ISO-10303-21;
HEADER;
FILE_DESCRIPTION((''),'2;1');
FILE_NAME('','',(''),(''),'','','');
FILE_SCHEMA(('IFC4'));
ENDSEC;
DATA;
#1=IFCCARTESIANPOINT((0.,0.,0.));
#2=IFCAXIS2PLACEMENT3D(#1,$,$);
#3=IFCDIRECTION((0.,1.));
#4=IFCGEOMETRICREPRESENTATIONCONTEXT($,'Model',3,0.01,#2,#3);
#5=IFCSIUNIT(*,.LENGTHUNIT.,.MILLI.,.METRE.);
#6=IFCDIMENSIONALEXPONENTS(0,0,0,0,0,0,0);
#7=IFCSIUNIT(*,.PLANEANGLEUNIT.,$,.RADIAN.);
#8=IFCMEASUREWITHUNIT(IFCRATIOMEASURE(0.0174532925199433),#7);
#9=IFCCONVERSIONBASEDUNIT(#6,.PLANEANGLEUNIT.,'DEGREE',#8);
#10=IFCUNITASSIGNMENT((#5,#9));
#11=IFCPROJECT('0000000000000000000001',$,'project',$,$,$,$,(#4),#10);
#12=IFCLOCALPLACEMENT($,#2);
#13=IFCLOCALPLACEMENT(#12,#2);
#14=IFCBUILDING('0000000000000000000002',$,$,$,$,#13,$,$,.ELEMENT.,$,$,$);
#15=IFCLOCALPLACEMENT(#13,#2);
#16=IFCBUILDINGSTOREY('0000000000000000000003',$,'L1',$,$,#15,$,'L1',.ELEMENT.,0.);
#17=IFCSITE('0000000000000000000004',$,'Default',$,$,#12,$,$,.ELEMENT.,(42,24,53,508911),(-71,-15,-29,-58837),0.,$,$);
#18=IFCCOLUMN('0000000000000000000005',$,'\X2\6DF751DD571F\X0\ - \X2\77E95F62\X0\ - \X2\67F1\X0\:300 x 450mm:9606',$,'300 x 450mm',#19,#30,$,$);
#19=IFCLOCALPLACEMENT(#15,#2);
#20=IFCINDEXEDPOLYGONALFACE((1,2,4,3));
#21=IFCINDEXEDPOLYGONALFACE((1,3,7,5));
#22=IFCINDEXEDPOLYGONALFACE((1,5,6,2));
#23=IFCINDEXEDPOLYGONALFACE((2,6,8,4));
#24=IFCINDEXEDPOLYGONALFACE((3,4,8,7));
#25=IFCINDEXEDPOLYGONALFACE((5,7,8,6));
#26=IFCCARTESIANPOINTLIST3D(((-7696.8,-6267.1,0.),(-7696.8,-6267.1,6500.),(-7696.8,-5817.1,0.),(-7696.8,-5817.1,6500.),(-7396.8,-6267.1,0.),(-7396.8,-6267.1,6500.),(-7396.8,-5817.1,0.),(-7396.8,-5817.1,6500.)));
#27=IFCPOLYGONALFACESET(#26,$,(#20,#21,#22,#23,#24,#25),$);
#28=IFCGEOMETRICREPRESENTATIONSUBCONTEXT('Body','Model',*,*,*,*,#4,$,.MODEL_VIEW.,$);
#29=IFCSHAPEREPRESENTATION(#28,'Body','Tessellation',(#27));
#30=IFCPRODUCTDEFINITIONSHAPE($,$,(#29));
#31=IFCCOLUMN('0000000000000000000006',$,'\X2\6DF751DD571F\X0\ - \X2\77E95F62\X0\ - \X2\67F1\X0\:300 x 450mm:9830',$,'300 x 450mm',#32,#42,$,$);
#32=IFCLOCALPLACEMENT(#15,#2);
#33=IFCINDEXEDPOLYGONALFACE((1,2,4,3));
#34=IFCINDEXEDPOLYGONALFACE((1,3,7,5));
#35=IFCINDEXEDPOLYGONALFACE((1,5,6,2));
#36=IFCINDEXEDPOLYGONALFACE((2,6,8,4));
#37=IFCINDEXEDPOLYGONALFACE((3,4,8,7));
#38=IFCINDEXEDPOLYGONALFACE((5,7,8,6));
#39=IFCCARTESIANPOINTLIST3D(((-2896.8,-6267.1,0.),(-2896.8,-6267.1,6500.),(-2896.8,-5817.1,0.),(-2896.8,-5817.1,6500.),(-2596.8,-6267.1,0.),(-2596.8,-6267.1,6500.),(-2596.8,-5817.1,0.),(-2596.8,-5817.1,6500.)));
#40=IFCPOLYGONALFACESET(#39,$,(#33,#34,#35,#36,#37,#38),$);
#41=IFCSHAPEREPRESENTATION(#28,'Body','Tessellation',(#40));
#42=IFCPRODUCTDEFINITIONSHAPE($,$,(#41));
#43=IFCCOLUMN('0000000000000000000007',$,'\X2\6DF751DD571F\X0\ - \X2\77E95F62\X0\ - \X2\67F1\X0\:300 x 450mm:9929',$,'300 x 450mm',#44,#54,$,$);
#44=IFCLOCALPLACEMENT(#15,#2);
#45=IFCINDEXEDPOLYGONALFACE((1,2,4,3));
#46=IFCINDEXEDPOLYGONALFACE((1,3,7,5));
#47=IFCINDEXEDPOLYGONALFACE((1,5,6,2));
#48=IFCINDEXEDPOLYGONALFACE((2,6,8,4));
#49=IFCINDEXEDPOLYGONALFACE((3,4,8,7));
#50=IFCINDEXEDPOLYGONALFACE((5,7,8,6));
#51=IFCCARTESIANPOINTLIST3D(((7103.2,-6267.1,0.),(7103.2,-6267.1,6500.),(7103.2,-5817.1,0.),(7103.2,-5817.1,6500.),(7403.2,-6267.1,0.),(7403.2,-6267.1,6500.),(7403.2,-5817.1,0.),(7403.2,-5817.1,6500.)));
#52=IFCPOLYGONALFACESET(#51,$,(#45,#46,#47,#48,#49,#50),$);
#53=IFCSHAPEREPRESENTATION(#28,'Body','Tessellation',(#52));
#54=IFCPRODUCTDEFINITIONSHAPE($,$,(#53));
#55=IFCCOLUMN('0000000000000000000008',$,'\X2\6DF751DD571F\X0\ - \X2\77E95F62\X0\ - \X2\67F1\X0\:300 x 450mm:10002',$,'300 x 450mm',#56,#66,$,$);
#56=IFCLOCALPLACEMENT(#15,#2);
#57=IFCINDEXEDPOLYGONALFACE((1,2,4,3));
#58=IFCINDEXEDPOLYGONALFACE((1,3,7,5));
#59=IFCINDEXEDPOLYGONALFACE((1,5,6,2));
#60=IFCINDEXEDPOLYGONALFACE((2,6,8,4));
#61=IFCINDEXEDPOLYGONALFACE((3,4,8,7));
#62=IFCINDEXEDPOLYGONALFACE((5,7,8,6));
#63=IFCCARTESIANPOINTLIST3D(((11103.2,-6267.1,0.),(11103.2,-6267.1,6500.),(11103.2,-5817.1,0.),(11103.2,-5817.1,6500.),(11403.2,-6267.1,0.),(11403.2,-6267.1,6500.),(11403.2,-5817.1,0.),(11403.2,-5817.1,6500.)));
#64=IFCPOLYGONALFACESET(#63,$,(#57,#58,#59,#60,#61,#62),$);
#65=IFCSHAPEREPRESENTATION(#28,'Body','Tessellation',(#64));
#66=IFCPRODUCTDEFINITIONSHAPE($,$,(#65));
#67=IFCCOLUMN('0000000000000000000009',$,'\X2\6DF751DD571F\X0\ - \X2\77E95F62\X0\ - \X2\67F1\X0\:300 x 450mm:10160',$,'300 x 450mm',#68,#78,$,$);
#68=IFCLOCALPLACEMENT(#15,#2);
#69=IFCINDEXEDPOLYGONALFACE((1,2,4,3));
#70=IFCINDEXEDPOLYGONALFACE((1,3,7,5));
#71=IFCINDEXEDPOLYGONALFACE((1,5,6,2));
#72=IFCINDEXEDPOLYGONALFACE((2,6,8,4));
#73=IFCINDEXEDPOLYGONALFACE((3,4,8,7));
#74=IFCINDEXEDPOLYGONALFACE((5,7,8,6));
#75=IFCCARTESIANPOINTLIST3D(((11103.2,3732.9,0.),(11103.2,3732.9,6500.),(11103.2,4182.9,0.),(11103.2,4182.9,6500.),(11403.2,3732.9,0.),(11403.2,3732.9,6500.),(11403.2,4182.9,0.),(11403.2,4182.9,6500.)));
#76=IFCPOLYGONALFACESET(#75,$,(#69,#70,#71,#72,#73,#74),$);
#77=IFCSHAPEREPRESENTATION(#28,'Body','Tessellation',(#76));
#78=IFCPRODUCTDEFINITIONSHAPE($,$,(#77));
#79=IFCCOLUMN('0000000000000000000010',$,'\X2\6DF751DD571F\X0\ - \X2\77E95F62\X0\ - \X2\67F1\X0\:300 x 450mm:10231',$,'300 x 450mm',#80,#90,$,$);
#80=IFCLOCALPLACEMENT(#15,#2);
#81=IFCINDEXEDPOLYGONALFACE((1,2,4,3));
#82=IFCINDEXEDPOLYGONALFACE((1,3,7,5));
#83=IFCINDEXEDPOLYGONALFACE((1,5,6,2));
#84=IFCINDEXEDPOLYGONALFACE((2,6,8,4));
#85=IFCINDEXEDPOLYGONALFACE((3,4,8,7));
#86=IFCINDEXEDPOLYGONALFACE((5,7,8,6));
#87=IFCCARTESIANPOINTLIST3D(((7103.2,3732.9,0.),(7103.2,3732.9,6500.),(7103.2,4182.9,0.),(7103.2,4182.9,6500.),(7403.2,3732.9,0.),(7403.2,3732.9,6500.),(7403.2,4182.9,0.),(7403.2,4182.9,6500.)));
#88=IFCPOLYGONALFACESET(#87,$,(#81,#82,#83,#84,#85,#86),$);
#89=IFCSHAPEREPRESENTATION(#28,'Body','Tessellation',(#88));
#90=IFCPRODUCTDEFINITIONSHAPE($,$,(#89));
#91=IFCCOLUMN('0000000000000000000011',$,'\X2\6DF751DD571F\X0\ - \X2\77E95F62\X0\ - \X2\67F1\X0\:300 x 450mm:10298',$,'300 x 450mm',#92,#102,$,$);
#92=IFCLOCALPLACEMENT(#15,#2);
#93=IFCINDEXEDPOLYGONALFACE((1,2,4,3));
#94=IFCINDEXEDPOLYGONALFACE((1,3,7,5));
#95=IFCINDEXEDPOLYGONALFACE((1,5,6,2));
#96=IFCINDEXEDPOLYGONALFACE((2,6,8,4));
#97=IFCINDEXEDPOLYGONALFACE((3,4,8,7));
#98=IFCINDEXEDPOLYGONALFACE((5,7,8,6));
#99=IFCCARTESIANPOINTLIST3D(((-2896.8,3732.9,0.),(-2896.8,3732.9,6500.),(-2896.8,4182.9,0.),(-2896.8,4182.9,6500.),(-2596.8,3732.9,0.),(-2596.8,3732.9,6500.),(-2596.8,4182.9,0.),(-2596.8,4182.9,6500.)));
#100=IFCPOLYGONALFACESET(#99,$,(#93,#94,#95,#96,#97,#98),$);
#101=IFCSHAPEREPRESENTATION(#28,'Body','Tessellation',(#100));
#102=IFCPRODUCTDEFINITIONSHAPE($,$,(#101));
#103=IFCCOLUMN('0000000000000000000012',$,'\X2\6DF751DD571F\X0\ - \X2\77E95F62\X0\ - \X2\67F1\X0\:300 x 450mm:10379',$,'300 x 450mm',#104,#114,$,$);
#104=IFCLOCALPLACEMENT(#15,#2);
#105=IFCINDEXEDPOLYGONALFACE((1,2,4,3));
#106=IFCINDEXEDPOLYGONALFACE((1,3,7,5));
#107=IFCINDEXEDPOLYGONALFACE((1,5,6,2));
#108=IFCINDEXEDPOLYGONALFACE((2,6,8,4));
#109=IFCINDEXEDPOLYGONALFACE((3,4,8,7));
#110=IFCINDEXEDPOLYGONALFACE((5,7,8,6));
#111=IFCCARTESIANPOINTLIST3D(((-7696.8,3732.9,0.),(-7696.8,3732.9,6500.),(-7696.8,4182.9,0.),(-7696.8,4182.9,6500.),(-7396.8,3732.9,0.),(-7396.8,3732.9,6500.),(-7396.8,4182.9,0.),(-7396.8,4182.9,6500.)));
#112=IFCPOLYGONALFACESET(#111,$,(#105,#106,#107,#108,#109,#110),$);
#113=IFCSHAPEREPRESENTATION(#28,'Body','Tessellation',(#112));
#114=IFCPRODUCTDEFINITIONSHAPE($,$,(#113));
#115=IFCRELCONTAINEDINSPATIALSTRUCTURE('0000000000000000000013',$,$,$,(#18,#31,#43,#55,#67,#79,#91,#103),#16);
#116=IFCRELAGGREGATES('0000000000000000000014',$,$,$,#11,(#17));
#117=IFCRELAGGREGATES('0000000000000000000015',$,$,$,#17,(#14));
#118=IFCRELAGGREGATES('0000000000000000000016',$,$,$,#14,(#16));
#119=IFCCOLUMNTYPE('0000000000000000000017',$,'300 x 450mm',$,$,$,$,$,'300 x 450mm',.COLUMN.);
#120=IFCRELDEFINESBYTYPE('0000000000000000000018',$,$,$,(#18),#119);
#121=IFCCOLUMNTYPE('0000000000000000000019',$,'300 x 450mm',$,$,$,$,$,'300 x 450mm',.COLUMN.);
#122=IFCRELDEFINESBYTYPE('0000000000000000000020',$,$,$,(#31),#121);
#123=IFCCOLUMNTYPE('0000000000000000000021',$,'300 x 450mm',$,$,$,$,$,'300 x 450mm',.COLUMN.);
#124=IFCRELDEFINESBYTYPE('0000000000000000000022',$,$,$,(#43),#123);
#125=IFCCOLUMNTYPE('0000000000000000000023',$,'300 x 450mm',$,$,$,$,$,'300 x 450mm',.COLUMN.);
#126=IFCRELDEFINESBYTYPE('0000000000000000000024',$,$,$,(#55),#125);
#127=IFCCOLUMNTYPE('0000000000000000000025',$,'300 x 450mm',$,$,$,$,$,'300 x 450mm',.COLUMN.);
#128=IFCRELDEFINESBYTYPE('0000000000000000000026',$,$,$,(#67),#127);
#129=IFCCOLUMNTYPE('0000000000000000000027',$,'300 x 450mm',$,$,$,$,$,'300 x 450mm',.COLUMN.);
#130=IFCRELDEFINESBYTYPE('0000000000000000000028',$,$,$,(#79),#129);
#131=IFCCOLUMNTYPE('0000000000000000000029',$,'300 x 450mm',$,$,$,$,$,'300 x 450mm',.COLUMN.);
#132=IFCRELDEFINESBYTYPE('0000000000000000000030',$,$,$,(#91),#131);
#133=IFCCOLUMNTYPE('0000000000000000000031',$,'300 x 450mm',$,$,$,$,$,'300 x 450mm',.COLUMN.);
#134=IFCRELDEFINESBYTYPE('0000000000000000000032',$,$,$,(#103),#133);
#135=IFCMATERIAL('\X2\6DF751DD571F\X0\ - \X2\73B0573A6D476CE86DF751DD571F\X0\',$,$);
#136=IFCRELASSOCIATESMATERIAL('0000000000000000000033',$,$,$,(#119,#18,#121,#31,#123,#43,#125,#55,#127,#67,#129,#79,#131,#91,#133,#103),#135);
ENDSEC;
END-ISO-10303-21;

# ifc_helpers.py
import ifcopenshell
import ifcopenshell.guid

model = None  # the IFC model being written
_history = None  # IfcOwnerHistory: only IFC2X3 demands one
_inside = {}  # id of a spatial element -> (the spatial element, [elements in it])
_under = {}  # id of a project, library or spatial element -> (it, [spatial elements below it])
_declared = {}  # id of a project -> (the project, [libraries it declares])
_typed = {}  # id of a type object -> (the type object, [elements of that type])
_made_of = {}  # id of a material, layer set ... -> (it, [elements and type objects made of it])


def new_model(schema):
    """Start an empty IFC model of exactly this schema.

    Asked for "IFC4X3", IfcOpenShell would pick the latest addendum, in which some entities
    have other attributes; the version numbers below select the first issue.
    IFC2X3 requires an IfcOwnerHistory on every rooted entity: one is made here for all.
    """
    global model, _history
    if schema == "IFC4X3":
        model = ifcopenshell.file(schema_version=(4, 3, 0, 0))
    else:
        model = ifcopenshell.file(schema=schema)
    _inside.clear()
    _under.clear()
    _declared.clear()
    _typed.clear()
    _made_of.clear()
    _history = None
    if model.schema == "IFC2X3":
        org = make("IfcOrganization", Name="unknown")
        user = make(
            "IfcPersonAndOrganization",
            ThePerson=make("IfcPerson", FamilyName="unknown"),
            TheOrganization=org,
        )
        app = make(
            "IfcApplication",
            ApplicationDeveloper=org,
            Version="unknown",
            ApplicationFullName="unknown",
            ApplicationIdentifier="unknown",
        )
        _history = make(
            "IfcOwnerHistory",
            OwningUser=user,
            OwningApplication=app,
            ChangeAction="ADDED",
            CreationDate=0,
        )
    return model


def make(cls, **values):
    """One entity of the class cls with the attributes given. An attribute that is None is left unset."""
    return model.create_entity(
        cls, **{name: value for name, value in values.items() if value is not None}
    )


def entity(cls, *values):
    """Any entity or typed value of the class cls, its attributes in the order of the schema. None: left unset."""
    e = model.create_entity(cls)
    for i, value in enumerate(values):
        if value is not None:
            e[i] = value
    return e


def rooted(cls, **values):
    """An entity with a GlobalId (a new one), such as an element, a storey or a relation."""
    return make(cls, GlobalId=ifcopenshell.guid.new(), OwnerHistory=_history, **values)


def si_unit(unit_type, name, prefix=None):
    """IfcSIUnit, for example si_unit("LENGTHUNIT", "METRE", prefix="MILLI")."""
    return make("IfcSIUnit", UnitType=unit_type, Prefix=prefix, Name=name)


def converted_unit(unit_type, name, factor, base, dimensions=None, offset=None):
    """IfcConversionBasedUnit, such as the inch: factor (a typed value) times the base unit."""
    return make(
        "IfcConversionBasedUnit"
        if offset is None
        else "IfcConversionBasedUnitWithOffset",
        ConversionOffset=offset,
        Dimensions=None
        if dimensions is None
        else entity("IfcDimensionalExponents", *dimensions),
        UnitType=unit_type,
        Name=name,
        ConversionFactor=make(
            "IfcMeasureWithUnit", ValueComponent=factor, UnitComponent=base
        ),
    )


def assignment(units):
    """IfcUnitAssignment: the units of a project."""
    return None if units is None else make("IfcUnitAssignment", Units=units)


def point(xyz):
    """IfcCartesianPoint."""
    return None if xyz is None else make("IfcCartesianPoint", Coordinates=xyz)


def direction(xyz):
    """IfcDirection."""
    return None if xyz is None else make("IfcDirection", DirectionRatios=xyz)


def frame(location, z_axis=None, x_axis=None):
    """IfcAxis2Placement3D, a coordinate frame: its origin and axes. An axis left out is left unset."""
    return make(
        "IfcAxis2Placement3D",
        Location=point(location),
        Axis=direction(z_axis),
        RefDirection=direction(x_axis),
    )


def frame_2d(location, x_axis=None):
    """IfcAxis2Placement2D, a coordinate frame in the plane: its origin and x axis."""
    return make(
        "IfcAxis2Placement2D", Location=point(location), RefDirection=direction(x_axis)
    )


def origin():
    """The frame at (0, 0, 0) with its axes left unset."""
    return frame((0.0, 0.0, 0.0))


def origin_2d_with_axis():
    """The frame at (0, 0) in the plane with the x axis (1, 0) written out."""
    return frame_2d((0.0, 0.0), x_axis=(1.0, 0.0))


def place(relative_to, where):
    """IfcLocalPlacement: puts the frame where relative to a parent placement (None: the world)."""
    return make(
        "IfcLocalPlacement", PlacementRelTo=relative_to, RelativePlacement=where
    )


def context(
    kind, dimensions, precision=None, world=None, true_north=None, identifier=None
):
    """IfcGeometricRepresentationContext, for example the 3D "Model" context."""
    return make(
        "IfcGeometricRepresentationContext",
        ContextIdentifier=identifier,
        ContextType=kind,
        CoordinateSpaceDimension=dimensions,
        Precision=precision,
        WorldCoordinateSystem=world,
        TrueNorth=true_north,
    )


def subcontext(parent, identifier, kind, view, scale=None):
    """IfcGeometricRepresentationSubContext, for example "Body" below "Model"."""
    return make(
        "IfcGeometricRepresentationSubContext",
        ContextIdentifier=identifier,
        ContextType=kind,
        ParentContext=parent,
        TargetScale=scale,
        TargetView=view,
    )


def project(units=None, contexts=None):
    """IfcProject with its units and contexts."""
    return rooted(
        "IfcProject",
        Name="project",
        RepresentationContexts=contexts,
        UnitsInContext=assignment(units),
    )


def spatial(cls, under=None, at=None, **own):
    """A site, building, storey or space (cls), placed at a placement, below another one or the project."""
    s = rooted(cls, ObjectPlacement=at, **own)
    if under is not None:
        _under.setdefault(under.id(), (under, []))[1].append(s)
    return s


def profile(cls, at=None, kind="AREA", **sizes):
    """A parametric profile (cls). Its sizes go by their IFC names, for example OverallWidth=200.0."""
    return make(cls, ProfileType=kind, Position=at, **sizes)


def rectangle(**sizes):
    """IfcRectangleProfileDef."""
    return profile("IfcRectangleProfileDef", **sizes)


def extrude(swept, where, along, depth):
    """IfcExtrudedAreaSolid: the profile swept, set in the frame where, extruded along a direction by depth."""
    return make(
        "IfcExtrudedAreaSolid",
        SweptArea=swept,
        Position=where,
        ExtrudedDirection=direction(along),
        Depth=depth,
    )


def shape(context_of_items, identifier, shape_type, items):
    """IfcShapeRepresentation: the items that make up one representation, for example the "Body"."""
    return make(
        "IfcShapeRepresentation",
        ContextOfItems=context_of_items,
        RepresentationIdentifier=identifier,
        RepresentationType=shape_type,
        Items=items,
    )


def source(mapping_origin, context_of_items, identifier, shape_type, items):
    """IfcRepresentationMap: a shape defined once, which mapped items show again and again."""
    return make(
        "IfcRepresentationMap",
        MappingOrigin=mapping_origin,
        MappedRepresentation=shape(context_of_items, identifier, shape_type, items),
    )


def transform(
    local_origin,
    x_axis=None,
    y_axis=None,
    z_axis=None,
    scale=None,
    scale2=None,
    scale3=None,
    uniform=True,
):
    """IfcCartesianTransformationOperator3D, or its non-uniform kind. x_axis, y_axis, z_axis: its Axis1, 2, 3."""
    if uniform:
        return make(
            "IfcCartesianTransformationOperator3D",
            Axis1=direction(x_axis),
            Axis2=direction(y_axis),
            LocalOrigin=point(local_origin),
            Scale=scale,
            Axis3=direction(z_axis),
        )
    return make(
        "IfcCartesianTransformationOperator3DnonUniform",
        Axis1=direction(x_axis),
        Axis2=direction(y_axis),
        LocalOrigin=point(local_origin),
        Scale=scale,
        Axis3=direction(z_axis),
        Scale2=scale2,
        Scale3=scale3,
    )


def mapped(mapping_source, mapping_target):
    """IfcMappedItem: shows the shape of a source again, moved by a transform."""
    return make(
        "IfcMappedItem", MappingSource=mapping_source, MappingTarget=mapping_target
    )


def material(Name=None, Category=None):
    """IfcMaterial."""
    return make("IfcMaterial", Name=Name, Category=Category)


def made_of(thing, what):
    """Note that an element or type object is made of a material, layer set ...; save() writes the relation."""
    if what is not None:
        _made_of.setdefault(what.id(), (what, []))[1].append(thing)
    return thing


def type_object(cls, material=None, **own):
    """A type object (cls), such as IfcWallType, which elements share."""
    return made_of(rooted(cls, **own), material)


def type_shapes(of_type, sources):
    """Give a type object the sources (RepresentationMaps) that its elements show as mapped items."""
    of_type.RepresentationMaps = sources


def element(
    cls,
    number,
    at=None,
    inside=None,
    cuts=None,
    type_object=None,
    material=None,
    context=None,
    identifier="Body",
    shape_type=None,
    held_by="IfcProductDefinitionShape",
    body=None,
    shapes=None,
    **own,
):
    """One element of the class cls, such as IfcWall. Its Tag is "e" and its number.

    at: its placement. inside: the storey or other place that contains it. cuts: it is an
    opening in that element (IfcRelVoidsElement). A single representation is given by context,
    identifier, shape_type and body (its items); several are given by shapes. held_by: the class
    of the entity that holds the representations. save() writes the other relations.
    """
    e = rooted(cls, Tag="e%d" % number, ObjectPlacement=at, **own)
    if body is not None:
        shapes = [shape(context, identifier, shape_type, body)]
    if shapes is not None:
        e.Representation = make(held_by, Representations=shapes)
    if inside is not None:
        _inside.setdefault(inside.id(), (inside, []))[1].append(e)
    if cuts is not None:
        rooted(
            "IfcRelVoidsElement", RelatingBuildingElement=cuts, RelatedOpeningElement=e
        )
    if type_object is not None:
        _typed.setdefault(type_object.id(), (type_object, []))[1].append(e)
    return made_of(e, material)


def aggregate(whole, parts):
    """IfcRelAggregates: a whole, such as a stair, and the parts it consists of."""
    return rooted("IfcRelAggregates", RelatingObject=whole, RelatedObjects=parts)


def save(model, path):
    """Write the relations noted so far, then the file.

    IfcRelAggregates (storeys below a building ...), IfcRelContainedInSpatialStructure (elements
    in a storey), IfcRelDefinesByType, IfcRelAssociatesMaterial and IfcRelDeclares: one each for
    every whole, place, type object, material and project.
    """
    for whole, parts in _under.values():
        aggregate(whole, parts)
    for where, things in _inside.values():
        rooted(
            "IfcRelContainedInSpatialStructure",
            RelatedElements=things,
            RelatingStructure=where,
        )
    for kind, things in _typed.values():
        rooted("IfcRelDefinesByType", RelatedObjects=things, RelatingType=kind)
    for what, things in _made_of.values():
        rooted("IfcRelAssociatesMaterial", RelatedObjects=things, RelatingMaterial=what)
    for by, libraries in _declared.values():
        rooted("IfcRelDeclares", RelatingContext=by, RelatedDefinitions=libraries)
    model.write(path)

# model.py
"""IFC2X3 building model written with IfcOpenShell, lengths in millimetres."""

from ifc_helpers import new_model, entity, si_unit, converted_unit, direction, frame, frame_2d, origin, origin_2d_with_axis, place, context, subcontext, project, spatial, rectangle, extrude, source, transform, mapped, material, type_object, type_shapes, element, save


model = new_model("IFC2X3")

# Units and contexts
model_context = context("Model", 3, precision=0.01, world=origin(), true_north=direction((0.0, 1.0)))
body_context = subcontext(model_context, "Body", "Model", "MODEL_VIEW")
ifc_project = project(units=[si_unit("LENGTHUNIT", "METRE", prefix="MILLI"), converted_unit("PLANEANGLEUNIT", "DEGREE", entity("IfcRatioMeasure", 0.0174532925199433), si_unit("PLANEANGLEUNIT", "RADIAN"), dimensions=[0, 0, 0, 0, 0, 0, 0])], contexts=[model_context])

# Site, building, storey
site_placement = place(None, origin())
site = spatial("IfcSite", under=ifc_project, at=site_placement, Name="Default", CompositionType="ELEMENT", RefLatitude=(42, 24, 53, 508911), RefLongitude=(-71, -15, -29, -58837), RefElevation=0.0)
building_placement = place(site_placement, origin())
building = spatial("IfcBuilding", under=site, at=building_placement, CompositionType="ELEMENT")
storey_placement = place(building_placement, origin())
storey = spatial("IfcBuildingStorey", under=building, at=storey_placement, Name="L1", LongName="L1", CompositionType="ELEMENT", Elevation=0.0)

# Columns
ifc_material = material(Name="混凝土 - 现场浇注混凝土")
column_type_1 = type_object("IfcColumnType", Name="300 x 450mm", ElementType="300 x 450mm", PredefinedType="COLUMN", material=ifc_material)
shared_shape_1 = source(origin(), body_context, "Body", "SweptSolid", [
    extrude(rectangle(XDim=450.0, YDim=300.0, at=frame_2d((0.0, 0.0), x_axis=(1.0, 0.0))), frame((-7546.8, -6042.1, 0.0), z_axis=(0.0, 0.0, 1.0), x_axis=(0.0, -1.0, 0.0)), (0.0, 0.0, 1.0), 6500.0),
])
type_shapes(column_type_1, [shared_shape_1])
column_1_placement = place(storey_placement, origin())
element("IfcColumn", 1, at=column_1_placement, inside=storey, type_object=column_type_1, material=ifc_material, Name="混凝土 - 矩形 - 柱:300 x 450mm:9606", ObjectType="300 x 450mm", context=body_context, shape_type="MappedRepresentation", body=[
    mapped(shared_shape_1, transform((0.0, 0.0, 0.0), scale=1.0)),
])
column_type_2 = type_object("IfcColumnType", Name="300 x 450mm", ElementType="300 x 450mm", PredefinedType="COLUMN", material=ifc_material)
shared_shape_2 = source(origin(), body_context, "Body", "SweptSolid", [
    extrude(rectangle(XDim=450.0, YDim=300.0, at=origin_2d_with_axis()), frame((-2746.8, -6042.1, 0.0), z_axis=(0.0, 0.0, 1.0), x_axis=(0.0, -1.0, 0.0)), (0.0, 0.0, 1.0), 6500.0),
])
type_shapes(column_type_2, [shared_shape_2])
column_2_placement = place(storey_placement, origin())
element("IfcColumn", 2, at=column_2_placement, inside=storey, type_object=column_type_2, material=ifc_material, Name="混凝土 - 矩形 - 柱:300 x 450mm:9830", ObjectType="300 x 450mm", context=body_context, shape_type="MappedRepresentation", body=[
    mapped(shared_shape_2, transform((0.0, 0.0, 0.0), scale=1.0)),
])
column_type_3 = type_object("IfcColumnType", Name="300 x 450mm", ElementType="300 x 450mm", PredefinedType="COLUMN", material=ifc_material)
shared_shape_3 = source(origin(), body_context, "Body", "SweptSolid", [
    extrude(rectangle(XDim=450.0, YDim=300.0, at=frame_2d((0.0, 0.0), x_axis=(1.0, 0.0))), frame((7253.2, -6042.1, 0.0), z_axis=(0.0, 0.0, 1.0), x_axis=(0.0, -1.0, 0.0)), (0.0, 0.0, 1.0), 6500.0),
])
type_shapes(column_type_3, [shared_shape_3])
column_3_placement = place(storey_placement, origin())
element("IfcColumn", 3, at=column_3_placement, inside=storey, type_object=column_type_3, material=ifc_material, Name="混凝土 - 矩形 - 柱:300 x 450mm:9929", ObjectType="300 x 450mm", context=body_context, shape_type="MappedRepresentation", body=[
    mapped(shared_shape_3, transform((0.0, 0.0, 0.0), scale=1.0)),
])
column_type_4 = type_object("IfcColumnType", Name="300 x 450mm", ElementType="300 x 450mm", PredefinedType="COLUMN", material=ifc_material)
shared_shape_4 = source(origin(), body_context, "Body", "SweptSolid", [
    extrude(rectangle(XDim=450.0, YDim=300.0, at=origin_2d_with_axis()), frame((11253.2, -6042.1, 0.0), z_axis=(0.0, 0.0, 1.0), x_axis=(0.0, -1.0, 0.0)), (0.0, 0.0, 1.0), 6500.0),
])
type_shapes(column_type_4, [shared_shape_4])
column_4_placement = place(storey_placement, origin())
element("IfcColumn", 4, at=column_4_placement, inside=storey, type_object=column_type_4, material=ifc_material, Name="混凝土 - 矩形 - 柱:300 x 450mm:10002", ObjectType="300 x 450mm", context=body_context, shape_type="MappedRepresentation", body=[
    mapped(shared_shape_4, transform((0.0, 0.0, 0.0), scale=1.0)),
])
column_type_5 = type_object("IfcColumnType", Name="300 x 450mm", ElementType="300 x 450mm", PredefinedType="COLUMN", material=ifc_material)
shared_shape_5 = source(origin(), body_context, "Body", "SweptSolid", [
    extrude(rectangle(XDim=450.0, YDim=300.0, at=frame_2d((0.0, 0.0), x_axis=(1.0, 0.0))), frame((11253.2, 3957.9, 0.0), z_axis=(0.0, 0.0, 1.0), x_axis=(0.0, -1.0, 0.0)), (0.0, 0.0, 1.0), 6500.0),
])
type_shapes(column_type_5, [shared_shape_5])
column_5_placement = place(storey_placement, origin())
element("IfcColumn", 5, at=column_5_placement, inside=storey, type_object=column_type_5, material=ifc_material, Name="混凝土 - 矩形 - 柱:300 x 450mm:10160", ObjectType="300 x 450mm", context=body_context, shape_type="MappedRepresentation", body=[
    mapped(shared_shape_5, transform((0.0, 0.0, 0.0), scale=1.0)),
])
column_type_6 = type_object("IfcColumnType", Name="300 x 450mm", ElementType="300 x 450mm", PredefinedType="COLUMN", material=ifc_material)
shared_shape_6 = source(origin(), body_context, "Body", "SweptSolid", [
    extrude(rectangle(XDim=450.0, YDim=300.0, at=frame_2d((0.0, 0.0), x_axis=(1.0, 0.0))), frame((7253.2, 3957.9, 0.0), z_axis=(0.0, 0.0, 1.0), x_axis=(0.0, -1.0, 0.0)), (0.0, 0.0, 1.0), 6500.0),
])
type_shapes(column_type_6, [shared_shape_6])
column_6_placement = place(storey_placement, origin())
element("IfcColumn", 6, at=column_6_placement, inside=storey, type_object=column_type_6, material=ifc_material, Name="混凝土 - 矩形 - 柱:300 x 450mm:10231", ObjectType="300 x 450mm", context=body_context, shape_type="MappedRepresentation", body=[
    mapped(shared_shape_6, transform((0.0, 0.0, 0.0), scale=1.0)),
])
column_type_7 = type_object("IfcColumnType", Name="300 x 450mm", ElementType="300 x 450mm", PredefinedType="COLUMN", material=ifc_material)
shared_shape_7 = source(origin(), body_context, "Body", "SweptSolid", [
    extrude(rectangle(XDim=450.0, YDim=300.0, at=frame_2d((0.0, 0.0), x_axis=(1.0, 0.0))), frame((-2746.8, 3957.9, 0.0), z_axis=(0.0, 0.0, 1.0), x_axis=(0.0, -1.0, 0.0)), (0.0, 0.0, 1.0), 6500.0),
])
type_shapes(column_type_7, [shared_shape_7])
column_7_placement = place(storey_placement, origin())
element("IfcColumn", 7, at=column_7_placement, inside=storey, type_object=column_type_7, material=ifc_material, Name="混凝土 - 矩形 - 柱:300 x 450mm:10298", ObjectType="300 x 450mm", context=body_context, shape_type="MappedRepresentation", body=[
    mapped(shared_shape_7, transform((0.0, 0.0, 0.0), scale=1.0)),
])
column_type_8 = type_object("IfcColumnType", Name="300 x 450mm", ElementType="300 x 450mm", PredefinedType="COLUMN", material=ifc_material)
shared_shape_8 = source(origin(), body_context, "Body", "SweptSolid", [
    extrude(rectangle(XDim=450.0, YDim=300.0, at=frame_2d((0.0, 0.0), x_axis=(1.0, 0.0))), frame((-7546.8, 3957.9, 0.0), z_axis=(0.0, 0.0, 1.0), x_axis=(0.0, -1.0, 0.0)), (0.0, 0.0, 1.0), 6500.0),
])
type_shapes(column_type_8, [shared_shape_8])
column_8_placement = place(storey_placement, origin())
element("IfcColumn", 8, at=column_8_placement, inside=storey, type_object=column_type_8, material=ifc_material, Name="混凝土 - 矩形 - 柱:300 x 450mm:10379", ObjectType="300 x 450mm", context=body_context, shape_type="MappedRepresentation", body=[
    mapped(shared_shape_8, transform((0.0, 0.0, 0.0), scale=1.0)),
])

save(model, "model.ifc")
